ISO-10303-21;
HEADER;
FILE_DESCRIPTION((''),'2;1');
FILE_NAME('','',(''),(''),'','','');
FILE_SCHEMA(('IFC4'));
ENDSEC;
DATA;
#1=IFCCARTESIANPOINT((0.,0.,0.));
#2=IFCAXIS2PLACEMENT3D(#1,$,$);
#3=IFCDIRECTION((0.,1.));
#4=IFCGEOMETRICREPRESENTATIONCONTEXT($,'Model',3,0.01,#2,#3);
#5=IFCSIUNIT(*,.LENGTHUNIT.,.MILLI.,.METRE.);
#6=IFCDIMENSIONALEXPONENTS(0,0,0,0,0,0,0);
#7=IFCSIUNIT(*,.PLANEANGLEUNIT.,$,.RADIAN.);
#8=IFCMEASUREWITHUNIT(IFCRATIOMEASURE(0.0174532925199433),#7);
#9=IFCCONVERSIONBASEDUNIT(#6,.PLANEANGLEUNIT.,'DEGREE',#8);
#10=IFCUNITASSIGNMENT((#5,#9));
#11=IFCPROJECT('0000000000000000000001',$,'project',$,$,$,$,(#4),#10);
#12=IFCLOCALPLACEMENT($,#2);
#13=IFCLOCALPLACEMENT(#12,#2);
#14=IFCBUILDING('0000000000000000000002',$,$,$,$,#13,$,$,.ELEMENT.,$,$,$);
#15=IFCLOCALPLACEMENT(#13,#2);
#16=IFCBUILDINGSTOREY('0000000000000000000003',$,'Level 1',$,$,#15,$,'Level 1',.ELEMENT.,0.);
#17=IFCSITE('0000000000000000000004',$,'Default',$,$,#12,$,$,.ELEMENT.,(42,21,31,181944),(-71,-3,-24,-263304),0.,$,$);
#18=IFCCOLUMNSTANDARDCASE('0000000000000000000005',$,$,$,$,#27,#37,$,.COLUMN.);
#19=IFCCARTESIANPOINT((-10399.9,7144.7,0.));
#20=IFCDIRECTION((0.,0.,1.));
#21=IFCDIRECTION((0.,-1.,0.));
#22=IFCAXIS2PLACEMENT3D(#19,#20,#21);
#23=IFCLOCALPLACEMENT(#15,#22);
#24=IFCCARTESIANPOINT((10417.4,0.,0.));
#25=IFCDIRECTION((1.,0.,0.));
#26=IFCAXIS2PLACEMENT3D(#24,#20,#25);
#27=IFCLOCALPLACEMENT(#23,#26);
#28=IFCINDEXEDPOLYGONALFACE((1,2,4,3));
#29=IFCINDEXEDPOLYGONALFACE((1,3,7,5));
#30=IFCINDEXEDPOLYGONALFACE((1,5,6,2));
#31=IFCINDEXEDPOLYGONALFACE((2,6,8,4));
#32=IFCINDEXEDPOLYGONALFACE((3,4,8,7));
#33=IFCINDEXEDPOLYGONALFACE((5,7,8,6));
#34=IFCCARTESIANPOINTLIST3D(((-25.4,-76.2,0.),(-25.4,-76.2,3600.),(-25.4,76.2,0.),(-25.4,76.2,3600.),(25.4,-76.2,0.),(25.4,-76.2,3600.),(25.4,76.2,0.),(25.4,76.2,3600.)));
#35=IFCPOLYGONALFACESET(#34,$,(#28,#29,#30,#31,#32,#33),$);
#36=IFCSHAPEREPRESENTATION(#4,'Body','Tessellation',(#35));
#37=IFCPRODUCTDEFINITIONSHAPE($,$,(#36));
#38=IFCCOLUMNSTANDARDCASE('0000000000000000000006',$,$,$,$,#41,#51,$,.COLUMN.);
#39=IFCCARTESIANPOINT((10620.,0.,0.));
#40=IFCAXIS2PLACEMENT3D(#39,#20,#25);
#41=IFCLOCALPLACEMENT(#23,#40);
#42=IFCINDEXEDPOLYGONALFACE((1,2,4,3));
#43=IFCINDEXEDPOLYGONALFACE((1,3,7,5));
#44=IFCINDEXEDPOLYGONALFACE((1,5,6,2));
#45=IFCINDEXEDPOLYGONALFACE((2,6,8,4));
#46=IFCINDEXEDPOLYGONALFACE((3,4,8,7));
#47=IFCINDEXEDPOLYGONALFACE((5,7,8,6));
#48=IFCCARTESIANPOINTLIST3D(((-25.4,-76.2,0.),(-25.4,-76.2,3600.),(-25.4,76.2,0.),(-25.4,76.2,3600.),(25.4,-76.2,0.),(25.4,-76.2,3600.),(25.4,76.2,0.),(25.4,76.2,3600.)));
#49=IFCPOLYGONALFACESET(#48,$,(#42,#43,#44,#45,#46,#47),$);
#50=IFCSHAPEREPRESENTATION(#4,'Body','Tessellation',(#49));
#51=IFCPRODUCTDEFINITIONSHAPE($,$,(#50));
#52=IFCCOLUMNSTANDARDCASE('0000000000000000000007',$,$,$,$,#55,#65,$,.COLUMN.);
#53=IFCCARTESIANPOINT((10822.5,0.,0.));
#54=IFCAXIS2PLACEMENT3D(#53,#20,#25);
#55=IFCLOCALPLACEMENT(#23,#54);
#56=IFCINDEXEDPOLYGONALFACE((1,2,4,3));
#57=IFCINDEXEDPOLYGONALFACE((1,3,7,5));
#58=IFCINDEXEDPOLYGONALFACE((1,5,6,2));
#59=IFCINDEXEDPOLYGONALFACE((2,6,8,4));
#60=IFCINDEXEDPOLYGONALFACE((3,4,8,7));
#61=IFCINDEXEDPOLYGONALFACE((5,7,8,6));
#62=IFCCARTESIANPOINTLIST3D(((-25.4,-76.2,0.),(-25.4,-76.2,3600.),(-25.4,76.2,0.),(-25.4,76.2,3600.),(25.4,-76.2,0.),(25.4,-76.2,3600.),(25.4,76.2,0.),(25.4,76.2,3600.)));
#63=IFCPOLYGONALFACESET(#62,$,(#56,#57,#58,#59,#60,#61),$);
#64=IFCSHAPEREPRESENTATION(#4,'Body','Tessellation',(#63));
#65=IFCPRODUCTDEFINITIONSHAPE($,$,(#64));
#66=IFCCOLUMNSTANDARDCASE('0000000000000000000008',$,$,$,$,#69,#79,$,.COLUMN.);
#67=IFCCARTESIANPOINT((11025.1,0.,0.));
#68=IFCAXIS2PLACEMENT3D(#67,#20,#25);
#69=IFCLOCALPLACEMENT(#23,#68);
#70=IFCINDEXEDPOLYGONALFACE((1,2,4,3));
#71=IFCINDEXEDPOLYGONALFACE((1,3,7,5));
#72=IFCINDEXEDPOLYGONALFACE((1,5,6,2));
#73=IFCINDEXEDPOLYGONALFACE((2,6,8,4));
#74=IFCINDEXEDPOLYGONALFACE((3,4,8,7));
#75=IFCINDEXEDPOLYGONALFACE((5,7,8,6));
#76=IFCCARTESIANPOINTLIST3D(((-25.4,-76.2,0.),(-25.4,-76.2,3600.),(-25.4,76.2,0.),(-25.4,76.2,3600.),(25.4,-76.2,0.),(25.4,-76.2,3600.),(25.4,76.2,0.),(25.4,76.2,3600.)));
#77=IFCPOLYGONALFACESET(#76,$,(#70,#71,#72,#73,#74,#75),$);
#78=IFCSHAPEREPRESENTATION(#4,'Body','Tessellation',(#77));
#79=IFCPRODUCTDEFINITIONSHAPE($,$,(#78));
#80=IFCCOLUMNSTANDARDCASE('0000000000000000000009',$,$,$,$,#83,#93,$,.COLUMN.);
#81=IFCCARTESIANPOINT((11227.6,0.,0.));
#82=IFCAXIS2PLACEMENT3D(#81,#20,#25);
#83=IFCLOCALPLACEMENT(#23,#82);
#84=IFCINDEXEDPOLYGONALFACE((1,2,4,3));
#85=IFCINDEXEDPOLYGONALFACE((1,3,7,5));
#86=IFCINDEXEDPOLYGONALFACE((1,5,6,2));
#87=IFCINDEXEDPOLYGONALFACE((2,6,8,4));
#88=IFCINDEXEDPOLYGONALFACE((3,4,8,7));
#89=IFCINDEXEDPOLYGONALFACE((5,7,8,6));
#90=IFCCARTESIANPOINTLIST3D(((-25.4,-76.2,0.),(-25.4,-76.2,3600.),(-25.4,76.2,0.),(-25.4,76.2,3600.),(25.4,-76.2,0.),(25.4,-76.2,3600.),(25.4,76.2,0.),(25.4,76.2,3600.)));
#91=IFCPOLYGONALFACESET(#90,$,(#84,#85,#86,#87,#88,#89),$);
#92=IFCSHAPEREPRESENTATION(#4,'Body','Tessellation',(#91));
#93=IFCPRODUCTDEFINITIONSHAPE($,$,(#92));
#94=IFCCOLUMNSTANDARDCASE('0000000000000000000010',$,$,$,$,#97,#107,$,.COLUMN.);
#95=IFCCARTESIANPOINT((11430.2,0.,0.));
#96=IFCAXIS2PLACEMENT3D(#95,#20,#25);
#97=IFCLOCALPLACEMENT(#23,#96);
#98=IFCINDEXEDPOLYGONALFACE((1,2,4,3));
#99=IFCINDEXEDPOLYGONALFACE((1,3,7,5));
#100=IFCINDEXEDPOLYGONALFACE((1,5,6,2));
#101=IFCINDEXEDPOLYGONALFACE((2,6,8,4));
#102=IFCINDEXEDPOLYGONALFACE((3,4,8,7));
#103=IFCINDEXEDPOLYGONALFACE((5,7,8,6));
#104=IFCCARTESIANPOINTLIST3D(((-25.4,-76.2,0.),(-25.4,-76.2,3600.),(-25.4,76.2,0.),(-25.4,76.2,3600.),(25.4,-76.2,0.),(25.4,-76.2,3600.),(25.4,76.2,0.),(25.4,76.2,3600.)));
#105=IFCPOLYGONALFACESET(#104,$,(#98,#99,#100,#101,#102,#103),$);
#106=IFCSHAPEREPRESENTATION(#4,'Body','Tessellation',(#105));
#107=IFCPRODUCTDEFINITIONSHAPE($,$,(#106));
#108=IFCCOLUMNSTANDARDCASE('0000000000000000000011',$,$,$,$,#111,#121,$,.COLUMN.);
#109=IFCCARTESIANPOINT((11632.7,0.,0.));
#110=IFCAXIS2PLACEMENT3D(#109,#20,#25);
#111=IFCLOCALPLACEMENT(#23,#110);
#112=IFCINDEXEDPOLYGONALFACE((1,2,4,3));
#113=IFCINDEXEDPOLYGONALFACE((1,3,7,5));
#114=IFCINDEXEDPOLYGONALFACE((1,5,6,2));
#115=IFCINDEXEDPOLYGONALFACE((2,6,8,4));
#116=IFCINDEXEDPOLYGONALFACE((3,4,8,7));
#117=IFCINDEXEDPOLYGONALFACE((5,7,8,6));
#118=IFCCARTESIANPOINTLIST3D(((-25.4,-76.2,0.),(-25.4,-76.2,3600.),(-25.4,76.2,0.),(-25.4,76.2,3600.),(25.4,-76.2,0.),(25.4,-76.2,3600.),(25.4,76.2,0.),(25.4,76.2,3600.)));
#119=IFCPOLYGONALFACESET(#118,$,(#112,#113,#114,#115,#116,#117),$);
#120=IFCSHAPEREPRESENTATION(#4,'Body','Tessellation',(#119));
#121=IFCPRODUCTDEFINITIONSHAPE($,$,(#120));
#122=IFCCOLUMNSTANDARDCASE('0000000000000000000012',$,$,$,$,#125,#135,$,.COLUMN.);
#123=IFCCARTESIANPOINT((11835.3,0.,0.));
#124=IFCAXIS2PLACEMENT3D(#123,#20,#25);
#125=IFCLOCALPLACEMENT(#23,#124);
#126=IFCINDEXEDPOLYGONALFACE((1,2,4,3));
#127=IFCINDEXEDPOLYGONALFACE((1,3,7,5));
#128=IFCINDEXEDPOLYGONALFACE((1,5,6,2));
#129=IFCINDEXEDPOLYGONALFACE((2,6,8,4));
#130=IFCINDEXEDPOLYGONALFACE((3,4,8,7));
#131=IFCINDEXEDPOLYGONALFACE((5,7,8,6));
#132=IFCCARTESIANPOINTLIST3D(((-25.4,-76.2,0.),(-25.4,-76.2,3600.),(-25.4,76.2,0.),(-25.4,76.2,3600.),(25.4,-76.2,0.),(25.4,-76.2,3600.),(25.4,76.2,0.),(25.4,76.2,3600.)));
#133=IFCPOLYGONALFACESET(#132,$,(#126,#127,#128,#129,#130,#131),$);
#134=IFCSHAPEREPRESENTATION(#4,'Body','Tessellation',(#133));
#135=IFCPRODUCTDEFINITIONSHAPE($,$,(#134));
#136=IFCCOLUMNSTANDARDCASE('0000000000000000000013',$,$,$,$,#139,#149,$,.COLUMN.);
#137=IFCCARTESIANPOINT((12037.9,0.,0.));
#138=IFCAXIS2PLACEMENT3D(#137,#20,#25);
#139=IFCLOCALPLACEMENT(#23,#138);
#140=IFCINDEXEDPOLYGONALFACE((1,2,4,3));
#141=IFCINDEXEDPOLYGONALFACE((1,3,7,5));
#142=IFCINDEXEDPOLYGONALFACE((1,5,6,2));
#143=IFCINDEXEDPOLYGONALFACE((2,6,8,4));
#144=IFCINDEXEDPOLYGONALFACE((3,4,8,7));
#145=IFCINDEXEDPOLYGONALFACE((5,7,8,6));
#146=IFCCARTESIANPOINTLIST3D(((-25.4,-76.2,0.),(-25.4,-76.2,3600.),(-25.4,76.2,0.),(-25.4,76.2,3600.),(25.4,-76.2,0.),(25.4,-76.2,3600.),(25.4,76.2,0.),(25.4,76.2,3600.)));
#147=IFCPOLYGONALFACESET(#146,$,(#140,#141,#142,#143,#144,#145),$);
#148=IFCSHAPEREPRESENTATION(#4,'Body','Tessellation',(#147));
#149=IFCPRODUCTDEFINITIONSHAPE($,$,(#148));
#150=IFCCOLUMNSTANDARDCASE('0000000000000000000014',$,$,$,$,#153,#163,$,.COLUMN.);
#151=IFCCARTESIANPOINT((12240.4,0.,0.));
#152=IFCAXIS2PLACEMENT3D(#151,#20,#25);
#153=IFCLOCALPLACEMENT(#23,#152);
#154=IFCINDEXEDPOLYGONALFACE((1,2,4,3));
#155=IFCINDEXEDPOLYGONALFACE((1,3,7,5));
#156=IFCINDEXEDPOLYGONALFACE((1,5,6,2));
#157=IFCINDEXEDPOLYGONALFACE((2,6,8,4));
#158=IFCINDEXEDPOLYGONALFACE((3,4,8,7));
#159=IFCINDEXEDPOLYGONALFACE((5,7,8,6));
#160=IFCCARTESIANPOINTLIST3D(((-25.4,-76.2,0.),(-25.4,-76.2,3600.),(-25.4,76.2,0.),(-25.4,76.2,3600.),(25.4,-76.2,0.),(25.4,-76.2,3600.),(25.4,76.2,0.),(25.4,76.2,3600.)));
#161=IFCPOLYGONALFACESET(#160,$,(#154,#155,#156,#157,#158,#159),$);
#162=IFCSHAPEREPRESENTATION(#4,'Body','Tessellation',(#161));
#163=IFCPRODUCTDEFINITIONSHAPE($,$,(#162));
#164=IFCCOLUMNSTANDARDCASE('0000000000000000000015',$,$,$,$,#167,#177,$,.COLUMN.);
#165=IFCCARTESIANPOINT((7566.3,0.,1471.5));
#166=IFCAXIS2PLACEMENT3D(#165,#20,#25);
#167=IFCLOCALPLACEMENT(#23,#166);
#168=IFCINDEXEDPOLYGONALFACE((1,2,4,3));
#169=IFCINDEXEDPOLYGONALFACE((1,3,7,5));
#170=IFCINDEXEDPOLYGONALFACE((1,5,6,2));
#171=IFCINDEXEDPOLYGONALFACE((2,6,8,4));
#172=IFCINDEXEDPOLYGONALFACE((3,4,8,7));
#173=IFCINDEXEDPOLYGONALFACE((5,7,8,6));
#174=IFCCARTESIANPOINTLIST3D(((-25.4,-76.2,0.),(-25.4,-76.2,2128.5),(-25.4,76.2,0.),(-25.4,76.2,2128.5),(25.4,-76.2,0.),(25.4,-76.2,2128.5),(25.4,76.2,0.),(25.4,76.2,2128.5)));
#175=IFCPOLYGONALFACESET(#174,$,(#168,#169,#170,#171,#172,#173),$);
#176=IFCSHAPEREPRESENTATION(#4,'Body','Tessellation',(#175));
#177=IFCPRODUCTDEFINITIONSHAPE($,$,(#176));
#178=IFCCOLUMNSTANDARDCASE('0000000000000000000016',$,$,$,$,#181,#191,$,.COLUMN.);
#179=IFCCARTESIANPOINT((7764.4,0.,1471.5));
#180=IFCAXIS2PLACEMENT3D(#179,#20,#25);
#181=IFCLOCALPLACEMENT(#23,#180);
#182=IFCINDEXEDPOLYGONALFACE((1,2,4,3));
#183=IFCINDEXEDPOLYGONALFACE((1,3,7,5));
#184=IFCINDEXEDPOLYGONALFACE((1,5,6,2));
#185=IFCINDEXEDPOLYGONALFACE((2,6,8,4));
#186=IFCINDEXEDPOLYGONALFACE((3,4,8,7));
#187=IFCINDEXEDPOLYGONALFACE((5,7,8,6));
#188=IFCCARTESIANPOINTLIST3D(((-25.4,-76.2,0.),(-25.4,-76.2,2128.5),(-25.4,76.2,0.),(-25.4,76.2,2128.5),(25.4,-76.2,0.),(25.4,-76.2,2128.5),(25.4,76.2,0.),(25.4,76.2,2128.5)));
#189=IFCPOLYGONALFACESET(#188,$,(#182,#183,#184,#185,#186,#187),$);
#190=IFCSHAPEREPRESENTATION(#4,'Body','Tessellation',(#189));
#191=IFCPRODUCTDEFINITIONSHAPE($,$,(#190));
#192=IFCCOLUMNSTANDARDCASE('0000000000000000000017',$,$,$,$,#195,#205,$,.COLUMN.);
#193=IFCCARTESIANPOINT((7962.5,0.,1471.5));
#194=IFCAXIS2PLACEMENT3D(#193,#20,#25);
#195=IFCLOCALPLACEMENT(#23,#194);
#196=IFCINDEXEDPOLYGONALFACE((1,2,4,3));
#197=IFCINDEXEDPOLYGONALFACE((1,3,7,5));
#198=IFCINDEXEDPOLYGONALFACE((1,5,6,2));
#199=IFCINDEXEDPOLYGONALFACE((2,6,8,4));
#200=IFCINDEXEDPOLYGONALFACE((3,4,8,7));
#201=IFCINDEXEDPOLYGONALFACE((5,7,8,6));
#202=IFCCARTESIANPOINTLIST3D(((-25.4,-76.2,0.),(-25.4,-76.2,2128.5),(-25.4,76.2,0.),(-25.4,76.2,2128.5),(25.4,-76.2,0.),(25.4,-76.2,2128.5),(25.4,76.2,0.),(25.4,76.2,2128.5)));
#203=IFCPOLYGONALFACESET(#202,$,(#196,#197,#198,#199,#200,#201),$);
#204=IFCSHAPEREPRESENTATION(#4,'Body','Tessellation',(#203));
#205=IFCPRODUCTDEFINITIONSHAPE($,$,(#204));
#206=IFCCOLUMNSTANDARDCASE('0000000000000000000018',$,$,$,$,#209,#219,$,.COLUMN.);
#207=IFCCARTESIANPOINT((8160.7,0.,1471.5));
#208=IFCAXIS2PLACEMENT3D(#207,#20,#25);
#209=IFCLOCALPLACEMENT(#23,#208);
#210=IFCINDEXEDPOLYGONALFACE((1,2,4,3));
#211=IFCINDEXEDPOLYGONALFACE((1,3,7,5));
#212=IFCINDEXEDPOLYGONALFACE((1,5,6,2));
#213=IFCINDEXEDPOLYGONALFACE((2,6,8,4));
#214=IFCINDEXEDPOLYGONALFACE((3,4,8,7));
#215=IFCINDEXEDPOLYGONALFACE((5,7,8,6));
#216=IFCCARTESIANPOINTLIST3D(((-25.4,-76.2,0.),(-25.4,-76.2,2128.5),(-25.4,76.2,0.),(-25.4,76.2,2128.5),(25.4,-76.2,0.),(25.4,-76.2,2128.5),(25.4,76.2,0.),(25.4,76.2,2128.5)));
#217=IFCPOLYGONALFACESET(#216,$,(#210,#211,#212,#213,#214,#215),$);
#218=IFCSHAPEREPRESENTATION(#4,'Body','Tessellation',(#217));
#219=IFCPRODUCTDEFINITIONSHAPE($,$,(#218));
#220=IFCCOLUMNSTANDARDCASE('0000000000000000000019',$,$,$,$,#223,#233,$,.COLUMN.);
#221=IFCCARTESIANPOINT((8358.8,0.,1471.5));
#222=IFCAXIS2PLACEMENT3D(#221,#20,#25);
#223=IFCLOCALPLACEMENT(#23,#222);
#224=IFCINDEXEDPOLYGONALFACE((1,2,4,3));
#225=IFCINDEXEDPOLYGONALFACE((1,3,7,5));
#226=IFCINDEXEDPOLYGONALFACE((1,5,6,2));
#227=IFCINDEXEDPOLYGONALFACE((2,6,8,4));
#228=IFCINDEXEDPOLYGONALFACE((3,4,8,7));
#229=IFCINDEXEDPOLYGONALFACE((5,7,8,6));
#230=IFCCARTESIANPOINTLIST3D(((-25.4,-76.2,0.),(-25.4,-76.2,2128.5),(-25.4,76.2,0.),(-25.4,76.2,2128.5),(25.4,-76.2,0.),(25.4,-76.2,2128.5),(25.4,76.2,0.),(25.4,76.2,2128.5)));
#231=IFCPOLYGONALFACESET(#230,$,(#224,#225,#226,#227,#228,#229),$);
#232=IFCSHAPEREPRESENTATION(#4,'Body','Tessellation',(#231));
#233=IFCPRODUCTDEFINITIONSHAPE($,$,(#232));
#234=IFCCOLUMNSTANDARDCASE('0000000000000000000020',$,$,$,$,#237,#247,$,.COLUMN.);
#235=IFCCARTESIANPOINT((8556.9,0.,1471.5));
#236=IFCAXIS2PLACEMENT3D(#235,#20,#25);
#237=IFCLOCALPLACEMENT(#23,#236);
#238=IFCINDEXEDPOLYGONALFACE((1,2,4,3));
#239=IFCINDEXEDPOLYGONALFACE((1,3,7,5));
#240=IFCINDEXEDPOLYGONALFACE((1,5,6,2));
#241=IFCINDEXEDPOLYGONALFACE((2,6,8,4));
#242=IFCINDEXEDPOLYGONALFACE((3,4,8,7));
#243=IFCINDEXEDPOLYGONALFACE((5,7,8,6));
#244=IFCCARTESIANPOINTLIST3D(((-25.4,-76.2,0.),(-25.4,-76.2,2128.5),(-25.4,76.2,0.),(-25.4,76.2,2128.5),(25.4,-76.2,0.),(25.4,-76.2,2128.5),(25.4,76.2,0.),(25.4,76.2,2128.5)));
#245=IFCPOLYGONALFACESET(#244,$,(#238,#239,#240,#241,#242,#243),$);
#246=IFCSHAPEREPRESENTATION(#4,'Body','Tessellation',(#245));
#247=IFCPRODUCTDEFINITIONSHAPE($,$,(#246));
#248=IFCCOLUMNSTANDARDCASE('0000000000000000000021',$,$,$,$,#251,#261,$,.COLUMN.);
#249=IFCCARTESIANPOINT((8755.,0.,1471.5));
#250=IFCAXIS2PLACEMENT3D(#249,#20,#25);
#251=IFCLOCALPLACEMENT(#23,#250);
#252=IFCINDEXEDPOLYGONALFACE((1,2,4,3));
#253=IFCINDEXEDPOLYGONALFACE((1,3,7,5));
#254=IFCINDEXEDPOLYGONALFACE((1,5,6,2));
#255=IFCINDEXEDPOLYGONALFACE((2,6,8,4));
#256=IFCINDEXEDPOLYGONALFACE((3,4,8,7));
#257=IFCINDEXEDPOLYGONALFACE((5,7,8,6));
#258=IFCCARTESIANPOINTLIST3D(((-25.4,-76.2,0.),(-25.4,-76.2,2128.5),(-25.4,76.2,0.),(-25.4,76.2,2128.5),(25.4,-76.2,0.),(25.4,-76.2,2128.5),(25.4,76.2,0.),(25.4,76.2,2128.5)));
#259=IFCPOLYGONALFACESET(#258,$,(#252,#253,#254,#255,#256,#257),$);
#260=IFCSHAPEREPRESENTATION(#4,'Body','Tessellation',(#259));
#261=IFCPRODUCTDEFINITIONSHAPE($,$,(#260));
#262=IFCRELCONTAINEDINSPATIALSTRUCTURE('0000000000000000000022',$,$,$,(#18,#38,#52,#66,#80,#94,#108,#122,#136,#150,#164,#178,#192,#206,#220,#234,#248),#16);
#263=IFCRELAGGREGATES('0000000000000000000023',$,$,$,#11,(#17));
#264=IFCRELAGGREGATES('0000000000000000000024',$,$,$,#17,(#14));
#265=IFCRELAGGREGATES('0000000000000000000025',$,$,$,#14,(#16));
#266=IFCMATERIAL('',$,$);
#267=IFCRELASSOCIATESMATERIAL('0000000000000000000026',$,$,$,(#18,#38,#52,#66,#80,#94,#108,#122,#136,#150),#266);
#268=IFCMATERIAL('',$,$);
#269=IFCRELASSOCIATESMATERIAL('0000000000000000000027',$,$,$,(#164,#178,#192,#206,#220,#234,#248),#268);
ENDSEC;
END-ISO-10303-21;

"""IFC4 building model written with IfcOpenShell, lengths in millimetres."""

from ifc_helpers import new_model, entity, si_unit, converted_unit, direction, frame, origin, place, context, project, spatial, rectangle, extrude, material, element, save


model = new_model("IFC4")

# Units and contexts
model_context = context("Model", 3, precision=0.01, world=origin(), true_north=direction((0.0, 1.0)))
ifc_project = project(units=[si_unit("LENGTHUNIT", "METRE", prefix="MILLI"), converted_unit("PLANEANGLEUNIT", "DEGREE", entity("IfcRatioMeasure", 0.0174532925199433), si_unit("PLANEANGLEUNIT", "RADIAN"), dimensions=[0, 0, 0, 0, 0, 0, 0])], contexts=[model_context])

# Site, building, storey
site_placement = place(None, origin())
site = spatial("IfcSite", under=ifc_project, at=site_placement, Name="Default", CompositionType="ELEMENT", RefLatitude=(42, 21, 31, 181944), RefLongitude=(-71, -3, -24, -263304), RefElevation=0.0)
building_placement = place(site_placement, origin())
building = spatial("IfcBuilding", under=site, at=building_placement, CompositionType="ELEMENT")
storey_placement = place(building_placement, origin())
storey = spatial("IfcBuildingStorey", under=building, at=storey_placement, Name="Level 1", LongName="Level 1", CompositionType="ELEMENT", Elevation=0.0)

# Columns
ifc_material_1 = material(Name="")
placement_1 = place(storey_placement, frame((-10399.9, 7144.7, 0.0), z_axis=(0.0, 0.0, 1.0), x_axis=(0.0, -1.0, 0.0)))
for number, where, z_axis, x_axis in (
    (1, (10417.4, 0.0, 0.0), (0.0, 0.0, 1.0), (1.0, 0.0, 0.0)),
    (2, (10620.0, 0.0, 0.0), (0.0, 0.0, 1.0), (1.0, 0.0, 0.0)),
    (3, (10822.5, 0.0, 0.0), (0.0, 0.0, 1.0), (1.0, 0.0, 0.0)),
    (4, (11025.1, 0.0, 0.0), (0.0, 0.0, 1.0), (1.0, 0.0, 0.0)),
    (5, (11227.6, 0.0, 0.0), (0.0, 0.0, 1.0), (1.0, 0.0, 0.0)),
    (6, (11430.2, 0.0, 0.0), (0.0, 0.0, 1.0), (1.0, 0.0, 0.0)),
    (7, (11632.7, 0.0, 0.0), (0.0, 0.0, 1.0), (1.0, 0.0, 0.0)),
    (8, (11835.3, 0.0, 0.0), (0.0, 0.0, 1.0), (1.0, 0.0, 0.0)),
    (9, (12037.9, 0.0, 0.0), (0.0, 0.0, 1.0), (1.0, 0.0, 0.0)),
    (10, (12240.4, 0.0, 0.0), (0.0, 0.0, 1.0), (1.0, 0.0, 0.0)),
):
    element("IfcColumnStandardCase", number, at=place(placement_1, frame(where, z_axis=z_axis, x_axis=x_axis)), inside=storey, material=ifc_material_1, PredefinedType="COLUMN", context=model_context, shape_type="SweptSolid", body=[
        extrude(rectangle(XDim=50.8, YDim=152.4), origin(), (0.0, 0.0, 1.0), 3600.0),
    ])
ifc_material_2 = material(Name="")
for number, where, z_axis, x_axis in (
    (11, (7566.3, 0.0, 1471.5), (0.0, 0.0, 1.0), (1.0, 0.0, 0.0)),
    (12, (7764.4, 0.0, 1471.5), (0.0, 0.0, 1.0), (1.0, 0.0, 0.0)),
    (13, (7962.5, 0.0, 1471.5), (0.0, 0.0, 1.0), (1.0, 0.0, 0.0)),
    (14, (8160.7, 0.0, 1471.5), (0.0, 0.0, 1.0), (1.0, 0.0, 0.0)),
    (15, (8358.8, 0.0, 1471.5), (0.0, 0.0, 1.0), (1.0, 0.0, 0.0)),
    (16, (8556.9, 0.0, 1471.5), (0.0, 0.0, 1.0), (1.0, 0.0, 0.0)),
    (17, (8755.0, 0.0, 1471.5), (0.0, 0.0, 1.0), (1.0, 0.0, 0.0)),
):
    element("IfcColumnStandardCase", number, at=place(placement_1, frame(where, z_axis=z_axis, x_axis=x_axis)), inside=storey, material=ifc_material_2, PredefinedType="COLUMN", context=model_context, shape_type="SweptSolid", body=[
        extrude(rectangle(XDim=50.8, YDim=152.4), origin(), (0.0, 0.0, 1.0), 2128.5),
    ])

save(model, "model.ifc")
